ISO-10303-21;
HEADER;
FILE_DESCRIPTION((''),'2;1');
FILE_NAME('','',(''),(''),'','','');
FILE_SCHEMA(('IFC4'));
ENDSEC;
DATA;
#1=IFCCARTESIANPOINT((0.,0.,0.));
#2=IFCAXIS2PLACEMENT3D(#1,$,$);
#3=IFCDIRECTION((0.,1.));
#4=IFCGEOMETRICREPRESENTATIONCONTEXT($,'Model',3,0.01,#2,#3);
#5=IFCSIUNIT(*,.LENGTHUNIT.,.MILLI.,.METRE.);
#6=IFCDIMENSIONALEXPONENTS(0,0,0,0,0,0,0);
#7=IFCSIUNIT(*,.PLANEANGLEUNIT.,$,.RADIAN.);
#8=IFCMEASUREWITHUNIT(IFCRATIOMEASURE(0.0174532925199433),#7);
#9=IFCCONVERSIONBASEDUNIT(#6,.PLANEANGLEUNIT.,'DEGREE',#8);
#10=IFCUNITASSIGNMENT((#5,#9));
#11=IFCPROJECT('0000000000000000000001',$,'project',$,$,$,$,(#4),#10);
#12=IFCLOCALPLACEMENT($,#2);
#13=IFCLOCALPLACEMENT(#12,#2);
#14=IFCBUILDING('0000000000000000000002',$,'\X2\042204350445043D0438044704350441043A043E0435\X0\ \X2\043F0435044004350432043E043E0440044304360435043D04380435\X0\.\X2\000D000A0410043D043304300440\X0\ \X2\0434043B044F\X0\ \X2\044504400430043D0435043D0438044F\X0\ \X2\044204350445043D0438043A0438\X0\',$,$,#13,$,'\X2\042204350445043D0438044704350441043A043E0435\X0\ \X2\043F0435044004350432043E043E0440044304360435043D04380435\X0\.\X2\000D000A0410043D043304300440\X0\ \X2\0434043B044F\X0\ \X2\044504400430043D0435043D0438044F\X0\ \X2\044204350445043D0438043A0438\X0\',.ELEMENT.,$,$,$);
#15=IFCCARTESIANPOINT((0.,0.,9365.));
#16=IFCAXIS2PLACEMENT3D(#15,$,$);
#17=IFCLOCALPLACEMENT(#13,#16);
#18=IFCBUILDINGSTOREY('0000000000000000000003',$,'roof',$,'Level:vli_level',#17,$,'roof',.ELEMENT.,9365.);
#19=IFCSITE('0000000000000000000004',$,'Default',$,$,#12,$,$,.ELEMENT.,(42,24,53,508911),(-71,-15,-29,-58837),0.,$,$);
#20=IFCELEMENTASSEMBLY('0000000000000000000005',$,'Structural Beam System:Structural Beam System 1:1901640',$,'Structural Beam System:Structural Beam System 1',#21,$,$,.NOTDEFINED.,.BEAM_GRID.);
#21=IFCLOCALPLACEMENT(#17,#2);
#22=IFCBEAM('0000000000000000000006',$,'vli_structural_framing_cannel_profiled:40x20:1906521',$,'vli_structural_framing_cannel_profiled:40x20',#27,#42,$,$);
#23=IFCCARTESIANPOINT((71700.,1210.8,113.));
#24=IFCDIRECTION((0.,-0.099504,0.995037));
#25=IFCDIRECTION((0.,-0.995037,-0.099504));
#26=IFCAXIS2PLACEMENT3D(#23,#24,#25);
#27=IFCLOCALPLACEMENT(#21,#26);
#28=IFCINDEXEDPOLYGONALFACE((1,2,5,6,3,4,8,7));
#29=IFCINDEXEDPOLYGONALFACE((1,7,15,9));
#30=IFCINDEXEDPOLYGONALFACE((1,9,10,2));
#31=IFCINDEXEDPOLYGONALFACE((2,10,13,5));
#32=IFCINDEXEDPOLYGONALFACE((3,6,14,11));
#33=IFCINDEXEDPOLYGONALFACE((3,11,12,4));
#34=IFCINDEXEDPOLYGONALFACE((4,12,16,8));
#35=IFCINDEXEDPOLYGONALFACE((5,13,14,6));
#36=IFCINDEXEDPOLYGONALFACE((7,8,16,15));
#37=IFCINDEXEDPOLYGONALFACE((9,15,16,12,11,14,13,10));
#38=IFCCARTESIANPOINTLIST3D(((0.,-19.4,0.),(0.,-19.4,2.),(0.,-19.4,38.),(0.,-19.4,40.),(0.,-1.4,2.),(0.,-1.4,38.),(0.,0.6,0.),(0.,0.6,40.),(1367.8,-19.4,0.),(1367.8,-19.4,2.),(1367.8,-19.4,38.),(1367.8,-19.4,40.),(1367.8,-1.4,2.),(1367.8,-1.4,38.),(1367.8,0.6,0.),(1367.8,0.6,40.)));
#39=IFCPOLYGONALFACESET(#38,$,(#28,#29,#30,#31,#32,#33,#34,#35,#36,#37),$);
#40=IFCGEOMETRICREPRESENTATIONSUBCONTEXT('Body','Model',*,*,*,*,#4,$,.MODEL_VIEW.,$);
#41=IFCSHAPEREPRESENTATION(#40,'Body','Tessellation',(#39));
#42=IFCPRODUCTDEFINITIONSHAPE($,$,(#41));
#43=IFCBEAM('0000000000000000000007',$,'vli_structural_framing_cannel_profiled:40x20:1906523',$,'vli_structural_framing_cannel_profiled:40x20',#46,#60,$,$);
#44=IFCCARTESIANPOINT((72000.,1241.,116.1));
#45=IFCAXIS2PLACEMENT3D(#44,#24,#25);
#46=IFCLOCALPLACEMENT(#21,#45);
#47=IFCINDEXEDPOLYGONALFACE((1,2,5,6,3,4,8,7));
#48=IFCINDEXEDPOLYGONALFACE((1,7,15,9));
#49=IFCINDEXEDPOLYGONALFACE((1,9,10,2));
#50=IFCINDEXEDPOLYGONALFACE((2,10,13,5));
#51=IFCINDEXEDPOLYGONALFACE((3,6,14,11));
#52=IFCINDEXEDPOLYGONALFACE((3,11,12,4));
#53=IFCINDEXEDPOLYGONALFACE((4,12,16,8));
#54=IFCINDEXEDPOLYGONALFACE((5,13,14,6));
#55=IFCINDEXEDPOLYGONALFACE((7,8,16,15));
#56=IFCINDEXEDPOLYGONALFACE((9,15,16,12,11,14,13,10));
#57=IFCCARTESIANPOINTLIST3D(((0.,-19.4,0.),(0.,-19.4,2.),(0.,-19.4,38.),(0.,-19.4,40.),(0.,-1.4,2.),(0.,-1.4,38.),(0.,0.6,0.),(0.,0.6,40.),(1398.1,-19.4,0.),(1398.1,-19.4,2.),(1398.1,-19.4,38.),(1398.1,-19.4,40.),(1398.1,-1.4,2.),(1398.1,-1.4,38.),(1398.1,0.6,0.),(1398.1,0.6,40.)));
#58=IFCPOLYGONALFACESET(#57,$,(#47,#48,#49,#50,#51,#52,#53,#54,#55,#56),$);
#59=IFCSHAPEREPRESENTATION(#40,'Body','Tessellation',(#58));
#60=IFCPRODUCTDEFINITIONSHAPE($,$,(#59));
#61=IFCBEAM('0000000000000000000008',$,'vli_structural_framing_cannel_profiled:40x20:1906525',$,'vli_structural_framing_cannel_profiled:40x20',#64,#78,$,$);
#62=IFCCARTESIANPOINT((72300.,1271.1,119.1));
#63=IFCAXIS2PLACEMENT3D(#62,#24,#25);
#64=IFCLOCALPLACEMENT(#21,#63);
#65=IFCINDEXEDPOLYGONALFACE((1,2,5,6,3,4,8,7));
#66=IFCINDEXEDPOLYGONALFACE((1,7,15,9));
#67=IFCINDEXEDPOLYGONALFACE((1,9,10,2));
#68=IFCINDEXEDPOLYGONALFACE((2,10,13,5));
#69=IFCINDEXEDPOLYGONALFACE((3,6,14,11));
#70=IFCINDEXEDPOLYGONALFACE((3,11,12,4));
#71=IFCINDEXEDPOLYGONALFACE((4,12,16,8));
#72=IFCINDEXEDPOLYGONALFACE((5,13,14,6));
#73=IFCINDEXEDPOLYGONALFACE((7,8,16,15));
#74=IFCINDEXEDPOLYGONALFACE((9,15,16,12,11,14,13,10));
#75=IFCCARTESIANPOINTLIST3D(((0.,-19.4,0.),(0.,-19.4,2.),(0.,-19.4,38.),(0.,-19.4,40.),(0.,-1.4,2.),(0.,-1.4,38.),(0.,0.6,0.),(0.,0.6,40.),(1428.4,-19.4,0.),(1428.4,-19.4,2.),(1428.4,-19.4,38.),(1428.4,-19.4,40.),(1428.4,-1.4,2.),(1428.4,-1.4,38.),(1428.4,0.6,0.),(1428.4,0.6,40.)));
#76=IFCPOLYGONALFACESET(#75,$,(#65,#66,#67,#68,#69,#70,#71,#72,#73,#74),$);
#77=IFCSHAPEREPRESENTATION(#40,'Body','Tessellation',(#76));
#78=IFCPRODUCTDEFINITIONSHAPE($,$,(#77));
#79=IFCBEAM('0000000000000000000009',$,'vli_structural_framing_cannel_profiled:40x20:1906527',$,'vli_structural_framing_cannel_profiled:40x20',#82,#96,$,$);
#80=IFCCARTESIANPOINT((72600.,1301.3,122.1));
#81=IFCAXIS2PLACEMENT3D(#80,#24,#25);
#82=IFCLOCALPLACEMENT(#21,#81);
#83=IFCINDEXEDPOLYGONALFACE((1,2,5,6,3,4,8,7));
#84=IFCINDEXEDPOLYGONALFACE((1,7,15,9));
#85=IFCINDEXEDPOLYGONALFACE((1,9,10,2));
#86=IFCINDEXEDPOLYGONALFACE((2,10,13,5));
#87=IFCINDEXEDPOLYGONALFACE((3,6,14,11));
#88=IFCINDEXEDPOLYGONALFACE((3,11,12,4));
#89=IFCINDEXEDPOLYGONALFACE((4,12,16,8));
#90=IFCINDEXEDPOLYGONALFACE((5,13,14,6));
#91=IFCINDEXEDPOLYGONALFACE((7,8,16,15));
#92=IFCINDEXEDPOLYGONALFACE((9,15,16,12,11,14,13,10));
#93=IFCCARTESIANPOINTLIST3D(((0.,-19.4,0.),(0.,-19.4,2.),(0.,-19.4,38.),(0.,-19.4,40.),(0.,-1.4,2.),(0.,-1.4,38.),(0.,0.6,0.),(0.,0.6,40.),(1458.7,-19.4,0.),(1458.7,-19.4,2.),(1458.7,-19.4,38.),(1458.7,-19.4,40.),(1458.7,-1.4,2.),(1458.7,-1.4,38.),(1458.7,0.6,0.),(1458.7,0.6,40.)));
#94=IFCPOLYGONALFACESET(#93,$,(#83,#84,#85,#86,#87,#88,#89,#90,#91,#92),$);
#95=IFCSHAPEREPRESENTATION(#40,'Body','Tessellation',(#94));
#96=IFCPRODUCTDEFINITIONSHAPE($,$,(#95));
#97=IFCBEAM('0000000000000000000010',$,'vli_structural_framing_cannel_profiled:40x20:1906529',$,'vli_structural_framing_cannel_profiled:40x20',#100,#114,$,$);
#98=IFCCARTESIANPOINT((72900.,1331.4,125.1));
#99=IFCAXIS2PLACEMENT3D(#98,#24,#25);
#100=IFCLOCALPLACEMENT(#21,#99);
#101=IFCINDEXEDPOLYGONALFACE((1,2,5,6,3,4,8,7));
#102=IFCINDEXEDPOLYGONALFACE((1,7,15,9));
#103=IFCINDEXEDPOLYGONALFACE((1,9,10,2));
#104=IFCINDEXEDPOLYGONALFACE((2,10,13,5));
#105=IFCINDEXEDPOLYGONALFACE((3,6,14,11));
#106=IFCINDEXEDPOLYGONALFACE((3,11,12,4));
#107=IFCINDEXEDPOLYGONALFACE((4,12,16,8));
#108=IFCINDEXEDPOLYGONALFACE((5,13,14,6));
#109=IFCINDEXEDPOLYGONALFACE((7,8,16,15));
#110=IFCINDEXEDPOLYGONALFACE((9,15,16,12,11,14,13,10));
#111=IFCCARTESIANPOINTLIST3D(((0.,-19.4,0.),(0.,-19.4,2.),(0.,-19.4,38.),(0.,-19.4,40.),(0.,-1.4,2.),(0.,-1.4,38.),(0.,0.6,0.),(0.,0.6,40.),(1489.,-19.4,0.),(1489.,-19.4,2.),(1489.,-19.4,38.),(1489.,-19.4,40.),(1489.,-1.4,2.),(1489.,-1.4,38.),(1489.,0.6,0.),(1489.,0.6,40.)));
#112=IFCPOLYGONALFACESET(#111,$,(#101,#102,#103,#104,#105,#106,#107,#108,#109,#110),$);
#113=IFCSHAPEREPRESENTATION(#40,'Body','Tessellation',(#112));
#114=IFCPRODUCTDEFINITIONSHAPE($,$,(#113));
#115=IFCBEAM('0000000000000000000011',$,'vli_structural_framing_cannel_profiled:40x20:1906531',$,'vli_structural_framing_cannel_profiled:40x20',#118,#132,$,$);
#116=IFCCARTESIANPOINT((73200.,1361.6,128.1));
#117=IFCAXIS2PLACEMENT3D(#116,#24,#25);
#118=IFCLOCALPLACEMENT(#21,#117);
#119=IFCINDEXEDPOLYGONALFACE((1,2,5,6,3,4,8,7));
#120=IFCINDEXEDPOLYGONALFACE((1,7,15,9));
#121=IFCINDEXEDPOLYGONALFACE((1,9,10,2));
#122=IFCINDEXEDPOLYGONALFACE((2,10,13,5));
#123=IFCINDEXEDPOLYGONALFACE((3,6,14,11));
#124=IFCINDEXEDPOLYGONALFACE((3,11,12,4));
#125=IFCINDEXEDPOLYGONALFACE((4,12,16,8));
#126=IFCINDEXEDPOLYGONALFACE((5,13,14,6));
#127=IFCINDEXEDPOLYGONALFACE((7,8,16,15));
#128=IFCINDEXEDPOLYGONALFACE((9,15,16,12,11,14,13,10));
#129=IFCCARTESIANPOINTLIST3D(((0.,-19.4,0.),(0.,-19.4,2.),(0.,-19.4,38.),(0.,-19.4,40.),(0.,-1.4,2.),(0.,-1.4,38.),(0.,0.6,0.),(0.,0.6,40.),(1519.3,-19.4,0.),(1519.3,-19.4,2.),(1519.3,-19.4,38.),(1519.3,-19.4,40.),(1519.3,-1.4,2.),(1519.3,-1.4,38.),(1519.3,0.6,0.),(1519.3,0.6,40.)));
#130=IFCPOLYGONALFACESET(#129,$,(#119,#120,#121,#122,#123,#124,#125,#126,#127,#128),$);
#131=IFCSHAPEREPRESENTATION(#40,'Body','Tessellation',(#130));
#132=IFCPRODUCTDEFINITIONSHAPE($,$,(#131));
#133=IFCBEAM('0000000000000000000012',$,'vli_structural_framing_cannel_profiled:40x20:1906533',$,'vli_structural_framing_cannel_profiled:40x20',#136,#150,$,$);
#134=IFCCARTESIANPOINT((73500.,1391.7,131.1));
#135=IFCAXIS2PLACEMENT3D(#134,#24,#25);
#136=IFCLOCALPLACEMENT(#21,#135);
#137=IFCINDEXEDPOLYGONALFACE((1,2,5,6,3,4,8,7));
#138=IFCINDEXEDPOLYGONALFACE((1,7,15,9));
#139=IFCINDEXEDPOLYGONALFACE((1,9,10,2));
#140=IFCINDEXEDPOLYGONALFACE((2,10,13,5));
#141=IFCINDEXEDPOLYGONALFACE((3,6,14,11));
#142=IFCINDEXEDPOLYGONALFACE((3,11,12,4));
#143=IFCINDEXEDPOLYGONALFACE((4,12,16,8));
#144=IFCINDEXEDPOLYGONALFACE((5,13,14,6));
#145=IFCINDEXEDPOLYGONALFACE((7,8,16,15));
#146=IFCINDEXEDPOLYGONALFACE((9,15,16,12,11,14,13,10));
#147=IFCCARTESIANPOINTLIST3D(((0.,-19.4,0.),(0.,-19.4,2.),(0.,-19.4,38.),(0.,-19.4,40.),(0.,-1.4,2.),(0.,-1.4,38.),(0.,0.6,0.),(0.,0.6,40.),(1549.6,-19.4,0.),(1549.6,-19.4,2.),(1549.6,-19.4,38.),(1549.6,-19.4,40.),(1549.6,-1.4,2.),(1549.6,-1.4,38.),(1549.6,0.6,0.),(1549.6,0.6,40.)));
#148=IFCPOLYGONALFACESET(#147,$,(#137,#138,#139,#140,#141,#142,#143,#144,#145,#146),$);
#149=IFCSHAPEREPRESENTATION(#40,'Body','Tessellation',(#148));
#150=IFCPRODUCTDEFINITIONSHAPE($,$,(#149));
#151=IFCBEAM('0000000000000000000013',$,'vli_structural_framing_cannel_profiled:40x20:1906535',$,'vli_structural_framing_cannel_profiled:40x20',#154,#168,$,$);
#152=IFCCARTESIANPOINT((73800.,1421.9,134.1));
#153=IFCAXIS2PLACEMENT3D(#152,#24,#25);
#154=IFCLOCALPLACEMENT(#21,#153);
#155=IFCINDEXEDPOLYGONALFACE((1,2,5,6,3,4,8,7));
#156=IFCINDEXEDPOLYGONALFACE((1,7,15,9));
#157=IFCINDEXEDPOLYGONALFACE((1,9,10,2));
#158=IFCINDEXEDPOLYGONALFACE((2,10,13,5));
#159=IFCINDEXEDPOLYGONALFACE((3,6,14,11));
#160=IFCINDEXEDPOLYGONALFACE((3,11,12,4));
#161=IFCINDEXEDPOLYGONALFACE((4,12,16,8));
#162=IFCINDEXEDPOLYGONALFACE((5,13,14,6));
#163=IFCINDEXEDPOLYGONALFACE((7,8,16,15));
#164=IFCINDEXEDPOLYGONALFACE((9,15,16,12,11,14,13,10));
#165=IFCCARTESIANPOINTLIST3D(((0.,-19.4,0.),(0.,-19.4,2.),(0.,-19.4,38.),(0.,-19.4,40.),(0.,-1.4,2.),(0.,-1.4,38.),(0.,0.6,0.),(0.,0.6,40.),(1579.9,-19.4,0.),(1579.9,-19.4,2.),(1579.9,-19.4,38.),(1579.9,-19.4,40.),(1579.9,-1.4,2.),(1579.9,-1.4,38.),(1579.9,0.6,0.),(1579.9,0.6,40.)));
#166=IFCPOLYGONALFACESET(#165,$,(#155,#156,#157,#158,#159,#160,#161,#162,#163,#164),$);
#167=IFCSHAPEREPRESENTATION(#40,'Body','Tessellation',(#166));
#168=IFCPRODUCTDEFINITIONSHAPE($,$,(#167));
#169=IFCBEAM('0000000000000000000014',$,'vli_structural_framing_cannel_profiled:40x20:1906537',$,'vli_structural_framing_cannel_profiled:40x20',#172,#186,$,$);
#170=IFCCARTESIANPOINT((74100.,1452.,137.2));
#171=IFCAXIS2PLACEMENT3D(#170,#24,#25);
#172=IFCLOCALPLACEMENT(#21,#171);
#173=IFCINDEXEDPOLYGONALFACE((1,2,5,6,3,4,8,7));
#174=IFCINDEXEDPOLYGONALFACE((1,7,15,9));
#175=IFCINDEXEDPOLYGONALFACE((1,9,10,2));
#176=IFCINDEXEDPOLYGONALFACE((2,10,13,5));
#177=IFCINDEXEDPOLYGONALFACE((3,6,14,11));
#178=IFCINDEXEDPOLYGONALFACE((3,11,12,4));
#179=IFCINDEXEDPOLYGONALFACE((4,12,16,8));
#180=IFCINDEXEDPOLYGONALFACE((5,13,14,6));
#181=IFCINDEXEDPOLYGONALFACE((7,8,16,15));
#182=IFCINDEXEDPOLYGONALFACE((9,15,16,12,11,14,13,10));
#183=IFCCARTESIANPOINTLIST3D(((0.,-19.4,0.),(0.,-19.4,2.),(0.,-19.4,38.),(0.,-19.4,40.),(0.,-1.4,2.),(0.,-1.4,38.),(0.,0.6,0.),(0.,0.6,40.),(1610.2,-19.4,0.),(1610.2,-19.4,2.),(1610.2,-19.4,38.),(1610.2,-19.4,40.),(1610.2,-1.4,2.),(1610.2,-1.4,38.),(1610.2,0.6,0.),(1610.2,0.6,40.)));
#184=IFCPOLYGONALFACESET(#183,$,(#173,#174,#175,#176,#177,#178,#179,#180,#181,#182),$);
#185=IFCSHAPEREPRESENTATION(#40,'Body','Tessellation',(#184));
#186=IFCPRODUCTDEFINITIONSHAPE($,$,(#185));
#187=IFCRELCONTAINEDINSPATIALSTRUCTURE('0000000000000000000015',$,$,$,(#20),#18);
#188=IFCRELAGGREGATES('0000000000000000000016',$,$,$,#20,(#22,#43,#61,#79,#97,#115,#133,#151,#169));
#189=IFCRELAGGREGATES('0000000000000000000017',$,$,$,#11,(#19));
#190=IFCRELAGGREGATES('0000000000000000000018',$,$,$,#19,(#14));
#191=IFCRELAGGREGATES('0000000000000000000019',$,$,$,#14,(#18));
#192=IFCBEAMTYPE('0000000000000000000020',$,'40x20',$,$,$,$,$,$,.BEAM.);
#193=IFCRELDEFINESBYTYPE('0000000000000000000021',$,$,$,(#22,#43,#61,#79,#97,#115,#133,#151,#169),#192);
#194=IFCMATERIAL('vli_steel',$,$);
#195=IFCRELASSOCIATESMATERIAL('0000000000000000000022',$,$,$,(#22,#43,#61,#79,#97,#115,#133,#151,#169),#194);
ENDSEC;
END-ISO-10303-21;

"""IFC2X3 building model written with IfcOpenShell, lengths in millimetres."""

from ifc_helpers import new_model, entity, si_unit, converted_unit, direction, frame, origin, place, context, subcontext, project, spatial, polyline, outline, extrude, material, type_object, element, aggregate, save


model = new_model("IFC2X3")

# Units and contexts
model_context = context("Model", 3, precision=0.01, world=origin(), true_north=direction((0.0, 1.0)))
body_context = subcontext(model_context, "Body", "Model", "MODEL_VIEW")
ifc_project = project(units=[si_unit("LENGTHUNIT", "METRE", prefix="MILLI"), converted_unit("PLANEANGLEUNIT", "DEGREE", entity("IfcRatioMeasure", 0.0174532925199433), si_unit("PLANEANGLEUNIT", "RADIAN"), dimensions=[0, 0, 0, 0, 0, 0, 0])], contexts=[model_context])

# Site, building, storey
site_placement = place(None, origin())
site = spatial("IfcSite", under=ifc_project, at=site_placement, Name="Default", CompositionType="ELEMENT", RefLatitude=(42, 24, 53, 508911), RefLongitude=(-71, -15, -29, -58837), RefElevation=0.0)
building_placement = place(site_placement, origin())
building = spatial("IfcBuilding", under=site, at=building_placement, Name="Техническое перевооружение.\r\nАнгар для хранения техники", LongName="Техническое перевооружение.\r\nАнгар для хранения техники", CompositionType="ELEMENT")
storey_placement = place(building_placement, frame((0.0, 0.0, 9365.0)))
storey = spatial("IfcBuildingStorey", under=building, at=storey_placement, Name="roof", ObjectType="Level:vli_level", LongName="roof", CompositionType="ELEMENT", Elevation=9365.0)

# Element assembly, beams
assembly_1_placement = place(storey_placement, origin())
assembly_1 = element("IfcElementAssembly", 1, at=assembly_1_placement, inside=storey, Name="Structural Beam System:Structural Beam System 1:1901640", ObjectType="Structural Beam System:Structural Beam System 1", AssemblyPlace="NOTDEFINED", PredefinedType="BEAM_GRID")
ifc_material = material(Name="vli_steel")
beam_type = type_object("IfcBeamType", Name="40x20", PredefinedType="BEAM")
beam_1_placement = place(assembly_1_placement, frame((71700.0, 1210.8, 113.0), z_axis=(0.0, -0.099504, 0.995037), x_axis=(0.0, -0.995037, -0.099504)))
beam_1 = element("IfcBeam", 2, at=beam_1_placement, type_object=beam_type, material=ifc_material, Name="vli_structural_framing_cannel_profiled:40x20:1906521", ObjectType="vli_structural_framing_cannel_profiled:40x20", context=body_context, shape_type="SweptSolid", body=[
    extrude(outline(polyline([(-20.0, -9.5), (-18.0, -9.5), (-18.0, 8.5), (18.0, 8.5), (18.0, -9.5), (20.0, -9.5), (20.0, 10.5), (-20.0, 10.5), (-20.0, -9.5)])), frame((0.0, -9.9, 20.0), z_axis=(1.0, 0.0, 0.0), x_axis=(0.0, 0.0, -1.0)), (0.0, 0.0, 1.0), 1367.8),
])
beam_2_placement = place(assembly_1_placement, frame((72000.0, 1241.0, 116.1), z_axis=(0.0, -0.099504, 0.995037), x_axis=(0.0, -0.995037, -0.099504)))
beam_2 = element("IfcBeam", 3, at=beam_2_placement, type_object=beam_type, material=ifc_material, Name="vli_structural_framing_cannel_profiled:40x20:1906523", ObjectType="vli_structural_framing_cannel_profiled:40x20", context=body_context, shape_type="SweptSolid", body=[
    extrude(outline(polyline([(-20.0, -9.5), (-18.0, -9.5), (-18.0, 8.5), (18.0, 8.5), (18.0, -9.5), (20.0, -9.5), (20.0, 10.5), (-20.0, 10.5), (-20.0, -9.5)])), frame((0.0, -9.9, 20.0), z_axis=(1.0, 0.0, 0.0), x_axis=(0.0, 0.0, -1.0)), (0.0, 0.0, 1.0), 1398.1),
])
beam_3_placement = place(assembly_1_placement, frame((72300.0, 1271.1, 119.1), z_axis=(0.0, -0.099504, 0.995037), x_axis=(0.0, -0.995037, -0.099504)))
beam_3 = element("IfcBeam", 4, at=beam_3_placement, type_object=beam_type, material=ifc_material, Name="vli_structural_framing_cannel_profiled:40x20:1906525", ObjectType="vli_structural_framing_cannel_profiled:40x20", context=body_context, shape_type="SweptSolid", body=[
    extrude(outline(polyline([(-20.0, -9.5), (-18.0, -9.5), (-18.0, 8.5), (18.0, 8.5), (18.0, -9.5), (20.0, -9.5), (20.0, 10.5), (-20.0, 10.5), (-20.0, -9.5)])), frame((0.0, -9.9, 20.0), z_axis=(1.0, 0.0, 0.0), x_axis=(0.0, 0.0, -1.0)), (0.0, 0.0, 1.0), 1428.4),
])
beam_4_placement = place(assembly_1_placement, frame((72600.0, 1301.3, 122.1), z_axis=(0.0, -0.099504, 0.995037), x_axis=(0.0, -0.995037, -0.099504)))
beam_4 = element("IfcBeam", 5, at=beam_4_placement, type_object=beam_type, material=ifc_material, Name="vli_structural_framing_cannel_profiled:40x20:1906527", ObjectType="vli_structural_framing_cannel_profiled:40x20", context=body_context, shape_type="SweptSolid", body=[
    extrude(outline(polyline([(-20.0, -9.5), (-18.0, -9.5), (-18.0, 8.5), (18.0, 8.5), (18.0, -9.5), (20.0, -9.5), (20.0, 10.5), (-20.0, 10.5), (-20.0, -9.5)])), frame((0.0, -9.9, 20.0), z_axis=(1.0, 0.0, 0.0), x_axis=(0.0, 0.0, -1.0)), (0.0, 0.0, 1.0), 1458.7),
])
beam_5_placement = place(assembly_1_placement, frame((72900.0, 1331.4, 125.1), z_axis=(0.0, -0.099504, 0.995037), x_axis=(0.0, -0.995037, -0.099504)))
beam_5 = element("IfcBeam", 6, at=beam_5_placement, type_object=beam_type, material=ifc_material, Name="vli_structural_framing_cannel_profiled:40x20:1906529", ObjectType="vli_structural_framing_cannel_profiled:40x20", context=body_context, shape_type="SweptSolid", body=[
    extrude(outline(polyline([(-20.0, -9.5), (-18.0, -9.5), (-18.0, 8.5), (18.0, 8.5), (18.0, -9.5), (20.0, -9.5), (20.0, 10.5), (-20.0, 10.5), (-20.0, -9.5)])), frame((0.0, -9.9, 20.0), z_axis=(1.0, 0.0, 0.0), x_axis=(0.0, 0.0, -1.0)), (0.0, 0.0, 1.0), 1489.0),
])
beam_6_placement = place(assembly_1_placement, frame((73200.0, 1361.6, 128.1), z_axis=(0.0, -0.099504, 0.995037), x_axis=(0.0, -0.995037, -0.099504)))
beam_6 = element("IfcBeam", 7, at=beam_6_placement, type_object=beam_type, material=ifc_material, Name="vli_structural_framing_cannel_profiled:40x20:1906531", ObjectType="vli_structural_framing_cannel_profiled:40x20", context=body_context, shape_type="SweptSolid", body=[
    extrude(outline(polyline([(-20.0, -9.5), (-18.0, -9.5), (-18.0, 8.5), (18.0, 8.5), (18.0, -9.5), (20.0, -9.5), (20.0, 10.5), (-20.0, 10.5), (-20.0, -9.5)])), frame((0.0, -9.9, 20.0), z_axis=(1.0, 0.0, 0.0), x_axis=(0.0, 0.0, -1.0)), (0.0, 0.0, 1.0), 1519.3),
])
beam_7_placement = place(assembly_1_placement, frame((73500.0, 1391.7, 131.1), z_axis=(0.0, -0.099504, 0.995037), x_axis=(0.0, -0.995037, -0.099504)))
beam_7 = element("IfcBeam", 8, at=beam_7_placement, type_object=beam_type, material=ifc_material, Name="vli_structural_framing_cannel_profiled:40x20:1906533", ObjectType="vli_structural_framing_cannel_profiled:40x20", context=body_context, shape_type="SweptSolid", body=[
    extrude(outline(polyline([(-20.0, -9.5), (-18.0, -9.5), (-18.0, 8.5), (18.0, 8.5), (18.0, -9.5), (20.0, -9.5), (20.0, 10.5), (-20.0, 10.5), (-20.0, -9.5)])), frame((0.0, -9.9, 20.0), z_axis=(1.0, 0.0, 0.0), x_axis=(0.0, 0.0, -1.0)), (0.0, 0.0, 1.0), 1549.6),
])
beam_8_placement = place(assembly_1_placement, frame((73800.0, 1421.9, 134.1), z_axis=(0.0, -0.099504, 0.995037), x_axis=(0.0, -0.995037, -0.099504)))
beam_8 = element("IfcBeam", 9, at=beam_8_placement, type_object=beam_type, material=ifc_material, Name="vli_structural_framing_cannel_profiled:40x20:1906535", ObjectType="vli_structural_framing_cannel_profiled:40x20", context=body_context, shape_type="SweptSolid", body=[
    extrude(outline(polyline([(-20.0, -9.5), (-18.0, -9.5), (-18.0, 8.5), (18.0, 8.5), (18.0, -9.5), (20.0, -9.5), (20.0, 10.5), (-20.0, 10.5), (-20.0, -9.5)])), frame((0.0, -9.9, 20.0), z_axis=(1.0, 0.0, 0.0), x_axis=(0.0, 0.0, -1.0)), (0.0, 0.0, 1.0), 1579.9),
])
beam_9_placement = place(assembly_1_placement, frame((74100.0, 1452.0, 137.2), z_axis=(0.0, -0.099504, 0.995037), x_axis=(0.0, -0.995037, -0.099504)))
beam_9 = element("IfcBeam", 10, at=beam_9_placement, type_object=beam_type, material=ifc_material, Name="vli_structural_framing_cannel_profiled:40x20:1906537", ObjectType="vli_structural_framing_cannel_profiled:40x20", context=body_context, shape_type="SweptSolid", body=[
    extrude(outline(polyline([(-20.0, -9.5), (-18.0, -9.5), (-18.0, 8.5), (18.0, 8.5), (18.0, -9.5), (20.0, -9.5), (20.0, 10.5), (-20.0, 10.5), (-20.0, -9.5)])), frame((0.0, -9.9, 20.0), z_axis=(1.0, 0.0, 0.0), x_axis=(0.0, 0.0, -1.0)), (0.0, 0.0, 1.0), 1610.2),
])
aggregate(assembly_1, [beam_1, beam_2, beam_3, beam_4, beam_5, beam_6, beam_7, beam_8, beam_9])

save(model, "model.ifc")
